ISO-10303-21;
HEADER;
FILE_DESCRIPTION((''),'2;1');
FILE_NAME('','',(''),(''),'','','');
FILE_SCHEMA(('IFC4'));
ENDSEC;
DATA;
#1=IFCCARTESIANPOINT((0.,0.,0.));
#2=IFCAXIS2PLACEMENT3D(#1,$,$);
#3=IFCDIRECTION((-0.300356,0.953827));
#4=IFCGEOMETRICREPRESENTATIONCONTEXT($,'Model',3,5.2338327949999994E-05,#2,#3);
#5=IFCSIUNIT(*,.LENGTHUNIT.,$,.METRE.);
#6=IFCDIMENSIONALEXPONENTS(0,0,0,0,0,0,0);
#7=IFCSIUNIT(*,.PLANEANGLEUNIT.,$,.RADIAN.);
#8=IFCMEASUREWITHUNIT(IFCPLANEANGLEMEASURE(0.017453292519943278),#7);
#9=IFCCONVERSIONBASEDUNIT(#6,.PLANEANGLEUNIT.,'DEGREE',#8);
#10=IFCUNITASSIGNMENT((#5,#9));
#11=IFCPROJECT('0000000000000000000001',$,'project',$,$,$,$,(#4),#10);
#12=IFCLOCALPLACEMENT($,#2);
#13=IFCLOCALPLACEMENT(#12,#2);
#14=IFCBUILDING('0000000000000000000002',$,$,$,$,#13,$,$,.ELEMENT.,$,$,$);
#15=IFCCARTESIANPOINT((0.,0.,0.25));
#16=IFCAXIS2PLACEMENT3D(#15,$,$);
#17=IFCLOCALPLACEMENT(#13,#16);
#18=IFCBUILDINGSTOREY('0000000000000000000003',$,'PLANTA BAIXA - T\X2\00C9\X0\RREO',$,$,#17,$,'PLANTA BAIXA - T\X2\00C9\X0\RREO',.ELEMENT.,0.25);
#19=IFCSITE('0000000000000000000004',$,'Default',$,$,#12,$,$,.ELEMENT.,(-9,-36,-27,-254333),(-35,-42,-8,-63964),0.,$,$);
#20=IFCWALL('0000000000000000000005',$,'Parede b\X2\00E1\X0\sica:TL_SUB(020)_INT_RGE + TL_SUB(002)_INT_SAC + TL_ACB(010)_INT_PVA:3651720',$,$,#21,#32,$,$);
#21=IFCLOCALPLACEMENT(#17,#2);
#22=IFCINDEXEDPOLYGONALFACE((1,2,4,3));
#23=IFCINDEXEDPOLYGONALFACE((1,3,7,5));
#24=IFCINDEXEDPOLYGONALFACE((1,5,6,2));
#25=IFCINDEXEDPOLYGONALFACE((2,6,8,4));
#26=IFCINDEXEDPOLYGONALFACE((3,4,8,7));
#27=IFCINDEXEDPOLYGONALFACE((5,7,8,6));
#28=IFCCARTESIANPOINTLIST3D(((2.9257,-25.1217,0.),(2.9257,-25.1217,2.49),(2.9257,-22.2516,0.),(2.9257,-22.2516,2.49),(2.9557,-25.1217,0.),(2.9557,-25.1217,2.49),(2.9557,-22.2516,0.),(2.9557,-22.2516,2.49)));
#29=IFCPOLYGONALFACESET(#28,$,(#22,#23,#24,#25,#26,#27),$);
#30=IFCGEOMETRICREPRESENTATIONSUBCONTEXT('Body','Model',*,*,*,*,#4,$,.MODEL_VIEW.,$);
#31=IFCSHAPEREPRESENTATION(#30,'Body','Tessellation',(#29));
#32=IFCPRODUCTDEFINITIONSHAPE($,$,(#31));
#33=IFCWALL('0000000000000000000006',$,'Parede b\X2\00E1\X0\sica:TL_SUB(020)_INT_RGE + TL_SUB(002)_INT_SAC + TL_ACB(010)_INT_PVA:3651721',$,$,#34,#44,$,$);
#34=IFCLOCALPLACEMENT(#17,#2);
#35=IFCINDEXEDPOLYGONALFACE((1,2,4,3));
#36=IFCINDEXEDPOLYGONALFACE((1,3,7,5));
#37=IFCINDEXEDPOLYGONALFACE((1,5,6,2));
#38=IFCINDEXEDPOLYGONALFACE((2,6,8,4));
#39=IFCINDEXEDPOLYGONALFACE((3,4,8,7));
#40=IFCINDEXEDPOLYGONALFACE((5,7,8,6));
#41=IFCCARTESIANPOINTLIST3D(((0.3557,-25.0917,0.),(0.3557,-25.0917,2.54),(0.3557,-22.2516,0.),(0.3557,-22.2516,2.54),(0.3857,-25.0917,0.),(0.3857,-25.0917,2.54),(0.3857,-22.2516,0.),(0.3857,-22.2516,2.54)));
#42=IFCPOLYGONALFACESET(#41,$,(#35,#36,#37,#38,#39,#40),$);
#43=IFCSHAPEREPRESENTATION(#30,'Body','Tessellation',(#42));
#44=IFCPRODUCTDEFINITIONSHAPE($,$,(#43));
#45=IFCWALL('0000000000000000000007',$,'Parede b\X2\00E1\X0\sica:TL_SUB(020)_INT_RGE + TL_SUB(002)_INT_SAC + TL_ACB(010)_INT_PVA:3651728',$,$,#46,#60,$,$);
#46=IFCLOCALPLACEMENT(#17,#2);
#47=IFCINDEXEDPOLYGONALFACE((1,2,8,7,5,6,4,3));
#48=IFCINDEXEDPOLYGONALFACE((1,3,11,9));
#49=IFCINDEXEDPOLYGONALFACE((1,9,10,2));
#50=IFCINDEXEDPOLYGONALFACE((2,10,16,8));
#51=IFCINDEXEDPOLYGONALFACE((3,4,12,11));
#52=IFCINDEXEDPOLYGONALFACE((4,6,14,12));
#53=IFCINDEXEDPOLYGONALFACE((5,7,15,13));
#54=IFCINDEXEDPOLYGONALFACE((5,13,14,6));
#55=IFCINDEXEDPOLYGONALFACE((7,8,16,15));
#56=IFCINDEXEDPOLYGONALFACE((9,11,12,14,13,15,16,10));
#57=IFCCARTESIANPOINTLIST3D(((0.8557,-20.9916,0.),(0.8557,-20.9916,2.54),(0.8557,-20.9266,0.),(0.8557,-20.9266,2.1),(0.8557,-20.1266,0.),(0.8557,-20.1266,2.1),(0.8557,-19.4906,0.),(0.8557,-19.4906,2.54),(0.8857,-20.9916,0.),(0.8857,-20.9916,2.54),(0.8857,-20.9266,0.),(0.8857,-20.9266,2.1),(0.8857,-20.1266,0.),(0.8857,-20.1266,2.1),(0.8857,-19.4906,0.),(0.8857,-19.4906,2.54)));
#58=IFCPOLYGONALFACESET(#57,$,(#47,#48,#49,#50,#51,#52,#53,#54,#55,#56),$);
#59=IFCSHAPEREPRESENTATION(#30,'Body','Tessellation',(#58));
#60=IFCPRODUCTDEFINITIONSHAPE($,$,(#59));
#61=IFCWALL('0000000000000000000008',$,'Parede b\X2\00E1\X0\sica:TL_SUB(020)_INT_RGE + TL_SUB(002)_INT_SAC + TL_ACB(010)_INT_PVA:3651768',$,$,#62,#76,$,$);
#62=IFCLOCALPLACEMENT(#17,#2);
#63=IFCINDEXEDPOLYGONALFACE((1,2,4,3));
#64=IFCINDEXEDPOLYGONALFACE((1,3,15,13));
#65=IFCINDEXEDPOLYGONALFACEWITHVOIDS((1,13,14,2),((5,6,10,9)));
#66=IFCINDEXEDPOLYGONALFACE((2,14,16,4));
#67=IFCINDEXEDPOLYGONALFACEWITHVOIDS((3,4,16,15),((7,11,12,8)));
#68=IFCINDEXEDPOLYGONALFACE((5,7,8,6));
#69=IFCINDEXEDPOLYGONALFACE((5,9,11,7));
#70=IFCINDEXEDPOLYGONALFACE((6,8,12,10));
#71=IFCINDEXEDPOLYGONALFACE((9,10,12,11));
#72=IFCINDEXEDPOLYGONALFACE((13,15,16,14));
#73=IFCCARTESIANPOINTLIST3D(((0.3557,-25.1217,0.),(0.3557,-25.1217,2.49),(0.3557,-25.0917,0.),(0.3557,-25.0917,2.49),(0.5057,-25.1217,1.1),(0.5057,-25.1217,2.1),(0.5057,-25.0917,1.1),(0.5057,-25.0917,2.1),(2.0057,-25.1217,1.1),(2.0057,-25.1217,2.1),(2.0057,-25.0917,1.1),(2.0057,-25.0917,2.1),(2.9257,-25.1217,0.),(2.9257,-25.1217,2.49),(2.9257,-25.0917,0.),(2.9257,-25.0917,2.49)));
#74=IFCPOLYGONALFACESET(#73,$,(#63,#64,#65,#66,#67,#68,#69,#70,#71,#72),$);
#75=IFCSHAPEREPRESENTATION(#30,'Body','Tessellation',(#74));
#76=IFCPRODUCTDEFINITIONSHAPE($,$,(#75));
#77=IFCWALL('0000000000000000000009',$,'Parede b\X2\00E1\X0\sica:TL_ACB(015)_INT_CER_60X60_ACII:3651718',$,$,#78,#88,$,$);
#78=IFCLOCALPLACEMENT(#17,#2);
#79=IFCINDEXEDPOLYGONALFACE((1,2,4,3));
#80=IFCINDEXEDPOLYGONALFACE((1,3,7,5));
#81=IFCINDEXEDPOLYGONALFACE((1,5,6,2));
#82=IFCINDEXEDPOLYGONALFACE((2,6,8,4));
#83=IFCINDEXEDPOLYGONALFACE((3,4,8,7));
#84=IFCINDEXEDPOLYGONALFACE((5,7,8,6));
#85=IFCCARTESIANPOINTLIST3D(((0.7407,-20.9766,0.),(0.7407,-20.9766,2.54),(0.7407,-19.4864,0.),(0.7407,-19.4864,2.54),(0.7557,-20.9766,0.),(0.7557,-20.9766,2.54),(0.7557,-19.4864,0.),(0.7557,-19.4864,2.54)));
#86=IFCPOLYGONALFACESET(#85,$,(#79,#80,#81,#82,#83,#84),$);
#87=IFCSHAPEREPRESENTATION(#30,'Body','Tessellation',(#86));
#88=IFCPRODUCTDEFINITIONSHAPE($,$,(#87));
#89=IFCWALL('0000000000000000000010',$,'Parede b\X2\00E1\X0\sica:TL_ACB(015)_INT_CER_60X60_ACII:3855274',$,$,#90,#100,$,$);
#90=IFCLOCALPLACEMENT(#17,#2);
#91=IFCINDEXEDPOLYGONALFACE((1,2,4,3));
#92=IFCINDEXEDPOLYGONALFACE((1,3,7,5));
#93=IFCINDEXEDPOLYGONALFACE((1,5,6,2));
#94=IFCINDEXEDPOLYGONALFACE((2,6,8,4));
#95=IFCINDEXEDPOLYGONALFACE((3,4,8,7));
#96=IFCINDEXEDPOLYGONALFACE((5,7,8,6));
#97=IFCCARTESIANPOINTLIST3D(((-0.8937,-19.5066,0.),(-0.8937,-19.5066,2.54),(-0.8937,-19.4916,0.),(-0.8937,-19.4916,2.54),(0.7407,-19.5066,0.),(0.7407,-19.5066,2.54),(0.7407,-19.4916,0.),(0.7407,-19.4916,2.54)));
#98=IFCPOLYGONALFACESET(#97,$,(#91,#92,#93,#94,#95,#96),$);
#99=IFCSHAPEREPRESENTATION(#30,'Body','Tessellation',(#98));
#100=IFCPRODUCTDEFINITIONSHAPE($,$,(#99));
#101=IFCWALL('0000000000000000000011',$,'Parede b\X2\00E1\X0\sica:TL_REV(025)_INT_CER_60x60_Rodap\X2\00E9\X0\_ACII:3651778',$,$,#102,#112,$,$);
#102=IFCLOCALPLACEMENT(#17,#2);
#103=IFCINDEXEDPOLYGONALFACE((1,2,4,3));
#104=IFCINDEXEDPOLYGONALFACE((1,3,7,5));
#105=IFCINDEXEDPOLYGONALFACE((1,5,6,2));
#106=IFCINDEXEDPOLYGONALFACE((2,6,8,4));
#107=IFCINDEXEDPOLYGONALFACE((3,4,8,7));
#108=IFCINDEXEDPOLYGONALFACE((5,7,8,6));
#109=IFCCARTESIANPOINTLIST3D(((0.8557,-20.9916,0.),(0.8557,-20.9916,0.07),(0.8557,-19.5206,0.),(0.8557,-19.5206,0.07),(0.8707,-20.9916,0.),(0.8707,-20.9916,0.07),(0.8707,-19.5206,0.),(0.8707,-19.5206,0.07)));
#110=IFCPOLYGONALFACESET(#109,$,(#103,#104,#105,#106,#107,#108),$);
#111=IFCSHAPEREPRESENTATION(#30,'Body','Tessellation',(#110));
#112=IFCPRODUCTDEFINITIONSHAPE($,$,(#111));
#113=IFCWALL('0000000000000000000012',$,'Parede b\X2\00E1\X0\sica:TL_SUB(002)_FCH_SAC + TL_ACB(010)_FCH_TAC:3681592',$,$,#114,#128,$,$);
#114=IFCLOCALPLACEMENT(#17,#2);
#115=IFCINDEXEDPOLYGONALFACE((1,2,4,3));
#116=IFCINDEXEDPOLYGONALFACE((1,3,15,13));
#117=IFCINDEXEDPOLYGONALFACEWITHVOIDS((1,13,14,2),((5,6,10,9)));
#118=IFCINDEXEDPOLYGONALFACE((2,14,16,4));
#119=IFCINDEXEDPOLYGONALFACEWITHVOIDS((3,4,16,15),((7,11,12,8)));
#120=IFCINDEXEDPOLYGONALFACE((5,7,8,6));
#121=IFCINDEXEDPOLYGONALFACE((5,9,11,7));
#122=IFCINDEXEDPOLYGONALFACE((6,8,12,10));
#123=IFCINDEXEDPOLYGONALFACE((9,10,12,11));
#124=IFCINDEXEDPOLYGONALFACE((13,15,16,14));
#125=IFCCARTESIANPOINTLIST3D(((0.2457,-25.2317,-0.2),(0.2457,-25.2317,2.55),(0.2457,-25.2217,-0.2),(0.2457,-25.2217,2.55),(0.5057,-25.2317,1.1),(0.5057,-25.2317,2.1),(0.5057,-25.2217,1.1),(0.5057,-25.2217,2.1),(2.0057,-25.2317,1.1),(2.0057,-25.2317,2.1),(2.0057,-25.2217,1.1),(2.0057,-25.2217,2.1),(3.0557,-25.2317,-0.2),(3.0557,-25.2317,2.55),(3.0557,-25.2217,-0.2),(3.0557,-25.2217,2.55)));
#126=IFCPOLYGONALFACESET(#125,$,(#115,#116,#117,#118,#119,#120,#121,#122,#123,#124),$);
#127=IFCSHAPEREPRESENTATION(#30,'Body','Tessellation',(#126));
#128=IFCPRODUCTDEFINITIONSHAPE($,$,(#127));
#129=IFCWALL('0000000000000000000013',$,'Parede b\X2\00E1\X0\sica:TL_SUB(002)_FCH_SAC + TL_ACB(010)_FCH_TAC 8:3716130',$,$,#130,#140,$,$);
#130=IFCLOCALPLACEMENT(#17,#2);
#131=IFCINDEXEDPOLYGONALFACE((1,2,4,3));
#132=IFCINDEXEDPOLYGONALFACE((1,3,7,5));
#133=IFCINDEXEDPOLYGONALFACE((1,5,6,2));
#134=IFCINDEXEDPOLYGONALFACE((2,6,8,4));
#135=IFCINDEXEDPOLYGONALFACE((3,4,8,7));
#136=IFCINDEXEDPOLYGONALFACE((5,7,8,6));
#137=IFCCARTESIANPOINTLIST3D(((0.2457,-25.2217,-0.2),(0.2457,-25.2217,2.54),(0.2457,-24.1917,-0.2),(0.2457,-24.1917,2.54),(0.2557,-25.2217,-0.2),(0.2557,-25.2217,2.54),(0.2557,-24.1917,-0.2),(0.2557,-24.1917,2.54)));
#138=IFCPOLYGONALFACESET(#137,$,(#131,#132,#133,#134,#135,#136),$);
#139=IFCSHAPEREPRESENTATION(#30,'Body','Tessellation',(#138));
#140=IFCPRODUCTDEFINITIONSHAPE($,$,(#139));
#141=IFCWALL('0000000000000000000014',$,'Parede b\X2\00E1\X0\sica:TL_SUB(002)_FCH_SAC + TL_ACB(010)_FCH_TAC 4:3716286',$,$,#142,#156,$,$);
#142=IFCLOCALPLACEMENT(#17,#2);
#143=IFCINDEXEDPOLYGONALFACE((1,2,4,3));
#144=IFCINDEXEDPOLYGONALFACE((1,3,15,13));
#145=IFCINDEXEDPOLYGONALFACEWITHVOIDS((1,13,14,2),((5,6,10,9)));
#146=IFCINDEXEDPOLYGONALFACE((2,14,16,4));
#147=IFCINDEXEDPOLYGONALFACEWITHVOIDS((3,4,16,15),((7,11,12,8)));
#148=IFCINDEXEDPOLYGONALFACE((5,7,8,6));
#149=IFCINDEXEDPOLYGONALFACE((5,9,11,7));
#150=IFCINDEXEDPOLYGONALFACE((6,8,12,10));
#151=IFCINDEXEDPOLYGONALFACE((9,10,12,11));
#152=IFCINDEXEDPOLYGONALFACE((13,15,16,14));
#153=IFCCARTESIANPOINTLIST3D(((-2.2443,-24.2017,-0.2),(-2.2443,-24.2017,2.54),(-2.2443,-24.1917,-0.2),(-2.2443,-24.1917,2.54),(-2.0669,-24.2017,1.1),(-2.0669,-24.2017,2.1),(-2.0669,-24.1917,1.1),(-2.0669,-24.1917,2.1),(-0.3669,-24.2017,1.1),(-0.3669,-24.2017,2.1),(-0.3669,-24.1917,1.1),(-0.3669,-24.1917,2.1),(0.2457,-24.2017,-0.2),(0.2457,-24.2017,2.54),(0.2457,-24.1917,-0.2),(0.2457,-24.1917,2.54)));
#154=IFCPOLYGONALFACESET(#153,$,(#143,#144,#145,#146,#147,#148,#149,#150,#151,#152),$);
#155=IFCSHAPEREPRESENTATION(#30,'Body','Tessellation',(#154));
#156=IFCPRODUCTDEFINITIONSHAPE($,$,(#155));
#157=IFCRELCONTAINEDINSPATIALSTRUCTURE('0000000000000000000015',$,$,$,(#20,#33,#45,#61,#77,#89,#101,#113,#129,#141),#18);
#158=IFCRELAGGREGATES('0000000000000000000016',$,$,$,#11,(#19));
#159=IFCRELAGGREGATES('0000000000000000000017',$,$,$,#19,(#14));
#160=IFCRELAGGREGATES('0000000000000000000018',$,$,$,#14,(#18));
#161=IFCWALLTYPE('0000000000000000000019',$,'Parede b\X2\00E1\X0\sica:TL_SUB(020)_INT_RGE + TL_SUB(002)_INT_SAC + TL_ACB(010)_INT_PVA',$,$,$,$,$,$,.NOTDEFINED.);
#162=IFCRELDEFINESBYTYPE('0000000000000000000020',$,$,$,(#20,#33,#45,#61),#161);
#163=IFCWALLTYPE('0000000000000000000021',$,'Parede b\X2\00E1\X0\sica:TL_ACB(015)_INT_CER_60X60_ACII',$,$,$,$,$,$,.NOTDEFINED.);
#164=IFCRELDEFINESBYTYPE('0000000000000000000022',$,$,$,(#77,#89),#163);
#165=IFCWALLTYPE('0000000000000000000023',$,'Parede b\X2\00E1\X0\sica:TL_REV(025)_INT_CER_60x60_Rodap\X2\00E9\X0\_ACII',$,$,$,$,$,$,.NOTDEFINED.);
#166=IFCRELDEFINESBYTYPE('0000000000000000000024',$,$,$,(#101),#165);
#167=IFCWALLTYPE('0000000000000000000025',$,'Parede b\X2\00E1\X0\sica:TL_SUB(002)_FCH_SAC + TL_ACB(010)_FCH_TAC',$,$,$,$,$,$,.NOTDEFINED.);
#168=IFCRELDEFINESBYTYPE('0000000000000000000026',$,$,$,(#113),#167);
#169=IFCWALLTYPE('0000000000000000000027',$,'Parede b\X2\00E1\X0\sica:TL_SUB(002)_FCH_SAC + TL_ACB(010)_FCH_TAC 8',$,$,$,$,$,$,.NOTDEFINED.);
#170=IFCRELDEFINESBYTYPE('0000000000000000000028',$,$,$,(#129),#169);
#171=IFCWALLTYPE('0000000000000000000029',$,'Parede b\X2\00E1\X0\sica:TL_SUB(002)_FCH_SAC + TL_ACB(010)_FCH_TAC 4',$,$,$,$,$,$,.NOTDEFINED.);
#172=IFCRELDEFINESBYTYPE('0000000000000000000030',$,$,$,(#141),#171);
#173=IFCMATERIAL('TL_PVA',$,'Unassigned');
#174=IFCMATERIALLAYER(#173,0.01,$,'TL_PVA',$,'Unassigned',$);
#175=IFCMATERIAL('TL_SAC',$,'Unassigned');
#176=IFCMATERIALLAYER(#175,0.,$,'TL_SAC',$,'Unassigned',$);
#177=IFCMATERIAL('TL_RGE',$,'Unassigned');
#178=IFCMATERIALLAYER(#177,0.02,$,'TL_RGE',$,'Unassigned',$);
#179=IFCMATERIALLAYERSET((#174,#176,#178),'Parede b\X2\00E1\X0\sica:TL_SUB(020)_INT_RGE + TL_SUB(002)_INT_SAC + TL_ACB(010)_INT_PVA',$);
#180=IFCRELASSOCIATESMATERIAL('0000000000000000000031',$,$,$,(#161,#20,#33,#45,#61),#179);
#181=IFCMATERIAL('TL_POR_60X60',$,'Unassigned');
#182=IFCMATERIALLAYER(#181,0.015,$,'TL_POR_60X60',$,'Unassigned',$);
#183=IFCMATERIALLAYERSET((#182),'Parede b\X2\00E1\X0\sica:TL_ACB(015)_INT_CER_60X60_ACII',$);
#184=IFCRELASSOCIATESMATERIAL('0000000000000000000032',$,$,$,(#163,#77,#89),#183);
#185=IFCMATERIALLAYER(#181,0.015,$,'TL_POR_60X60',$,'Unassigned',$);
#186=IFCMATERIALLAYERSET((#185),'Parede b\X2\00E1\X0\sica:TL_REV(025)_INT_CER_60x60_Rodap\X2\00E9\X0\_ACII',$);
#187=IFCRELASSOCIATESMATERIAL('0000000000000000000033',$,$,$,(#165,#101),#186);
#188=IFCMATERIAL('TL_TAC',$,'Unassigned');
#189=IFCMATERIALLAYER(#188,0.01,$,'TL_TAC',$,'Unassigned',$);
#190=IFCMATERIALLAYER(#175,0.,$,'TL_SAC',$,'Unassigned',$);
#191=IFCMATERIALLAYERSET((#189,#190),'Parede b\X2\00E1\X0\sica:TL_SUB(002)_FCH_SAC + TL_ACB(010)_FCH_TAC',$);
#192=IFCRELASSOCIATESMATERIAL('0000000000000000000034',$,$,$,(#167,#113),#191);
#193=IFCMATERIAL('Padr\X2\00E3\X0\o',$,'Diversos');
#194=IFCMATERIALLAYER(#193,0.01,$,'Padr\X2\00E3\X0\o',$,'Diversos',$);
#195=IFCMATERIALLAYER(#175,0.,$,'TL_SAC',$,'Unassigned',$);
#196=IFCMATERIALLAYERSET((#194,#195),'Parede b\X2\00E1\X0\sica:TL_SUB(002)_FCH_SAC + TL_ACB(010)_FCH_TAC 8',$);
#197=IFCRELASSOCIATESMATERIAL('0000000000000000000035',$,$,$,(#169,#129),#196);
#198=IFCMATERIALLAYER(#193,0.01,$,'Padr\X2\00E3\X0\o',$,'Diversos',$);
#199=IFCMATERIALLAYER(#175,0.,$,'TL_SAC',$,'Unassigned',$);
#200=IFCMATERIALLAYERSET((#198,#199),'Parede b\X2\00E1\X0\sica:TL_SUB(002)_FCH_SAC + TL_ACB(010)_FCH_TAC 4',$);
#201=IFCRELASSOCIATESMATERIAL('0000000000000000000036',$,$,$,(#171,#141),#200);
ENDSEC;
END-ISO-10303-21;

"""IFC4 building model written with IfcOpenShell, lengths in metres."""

from ifc_helpers import new_model, entity, si_unit, converted_unit, direction, frame, frame_2d, origin, place, context, subcontext, project, spatial, rectangle, extrude, material, layer, layer_set, layer_usage, type_object, element, save


model = new_model("IFC4")

# Units and contexts
model_context = context("Model", 3, precision=5.2338327949999994e-05, world=origin(), true_north=direction((-0.300356, 0.953827)))
body_context = subcontext(model_context, "Body", "Model", "MODEL_VIEW")
ifc_project = project(units=[si_unit("LENGTHUNIT", "METRE"), converted_unit("PLANEANGLEUNIT", "DEGREE", entity("IfcPlaneAngleMeasure", 0.017453292519943278), si_unit("PLANEANGLEUNIT", "RADIAN"), dimensions=[0, 0, 0, 0, 0, 0, 0])], contexts=[model_context])

# Site, building, storey
site_placement = place(None, origin())
site = spatial("IfcSite", under=ifc_project, at=site_placement, Name="Default", CompositionType="ELEMENT", RefLatitude=(-9, -36, -27, -254333), RefLongitude=(-35, -42, -8, -63964), RefElevation=0.0)
building_placement = place(site_placement, origin())
building = spatial("IfcBuilding", under=site, at=building_placement, CompositionType="ELEMENT")
storey_placement = place(building_placement, frame((0.0, 0.0, 0.25)))
storey = spatial("IfcBuildingStorey", under=building, at=storey_placement, Name="PLANTA BAIXA - TÉRREO", LongName="PLANTA BAIXA - TÉRREO", CompositionType="ELEMENT", Elevation=0.25)

# Shared definitions
ifc_material_1 = material(Name="TL_PVA", Category="Unassigned")
ifc_layer_1 = layer(ifc_material_1, 0.01, Name="TL_PVA", Category="Unassigned")
ifc_material_2 = material(Name="TL_SAC", Category="Unassigned")
ifc_layer_2 = layer(ifc_material_2, 0.0, Name="TL_SAC", Category="Unassigned")
ifc_material_3 = material(Name="TL_RGE", Category="Unassigned")
ifc_layer_3 = layer(ifc_material_3, 0.02, Name="TL_RGE", Category="Unassigned")
ifc_layer_set_1 = layer_set([ifc_layer_1, ifc_layer_2, ifc_layer_3], Name="Parede básica:TL_SUB(020)_INT_RGE + TL_SUB(002)_INT_SAC + TL_ACB(010)_INT_PVA")
wall_type_1 = type_object("IfcWallType", Name="Parede básica:TL_SUB(020)_INT_RGE + TL_SUB(002)_INT_SAC + TL_ACB(010)_INT_PVA", PredefinedType="NOTDEFINED", material=ifc_layer_set_1)

# Walls
ifc_layer_usage_1 = layer_usage(ifc_layer_set_1, "AXIS2", "POSITIVE", -0.015)
wall_1_placement = place(storey_placement, frame((2.9407, -22.2516, 0.0), z_axis=(0.0, 0.0, 1.0), x_axis=(0.0, -1.0, 0.0)))
element("IfcWall", 1, at=wall_1_placement, inside=storey, type_object=wall_type_1, material=ifc_layer_usage_1, Name="Parede básica:TL_SUB(020)_INT_RGE + TL_SUB(002)_INT_SAC + TL_ACB(010)_INT_PVA:3651720", context=body_context, shape_type="SweptSolid", body=[
    extrude(rectangle(XDim=2.8701, YDim=0.03, at=frame_2d((1.4351, 0.0), x_axis=(-1.0, 0.0))), origin(), (0.0, 0.0, 1.0), 2.49),
])
ifc_layer_usage_2 = layer_usage(ifc_layer_set_1, "AXIS2", "POSITIVE", -0.015)
wall_2_placement = place(storey_placement, frame((0.3707, -25.0917, 0.0), z_axis=(0.0, 0.0, 1.0), x_axis=(0.0, 1.0, 0.0)))
element("IfcWall", 2, at=wall_2_placement, inside=storey, type_object=wall_type_1, material=ifc_layer_usage_2, Name="Parede básica:TL_SUB(020)_INT_RGE + TL_SUB(002)_INT_SAC + TL_ACB(010)_INT_PVA:3651721", context=body_context, shape_type="SweptSolid", body=[
    extrude(rectangle(XDim=2.8401, YDim=0.03, at=frame_2d((1.4201, 0.0), x_axis=(-1.0, 0.0))), origin(), (0.0, 0.0, 1.0), 2.54),
])

# Walls, openings
ifc_layer_usage_3 = layer_usage(ifc_layer_set_1, "AXIS2", "POSITIVE", -0.015)
wall_3_placement = place(storey_placement, frame((0.8707, -20.9916, 0.0), z_axis=(0.0, 0.0, 1.0), x_axis=(0.0, 1.0, 0.0)))
wall_3 = element("IfcWall", 3, at=wall_3_placement, inside=storey, type_object=wall_type_1, material=ifc_layer_usage_3, Name="Parede básica:TL_SUB(020)_INT_RGE + TL_SUB(002)_INT_SAC + TL_ACB(010)_INT_PVA:3651728", context=body_context, shape_type="SweptSolid", body=[
    extrude(rectangle(XDim=1.501, YDim=0.03, at=frame_2d((0.7505, 0.0), x_axis=(-1.0, 0.0))), origin(), (0.0, 0.0, 1.0), 2.54),
])
opening_1_placement = place(wall_3_placement, frame((0.065, -0.015, 0.0)))
element("IfcOpeningElement", 4, at=opening_1_placement, cuts=wall_3, PredefinedType="OPENING", context=body_context, shape_type="SweptSolid", body=[
    extrude(rectangle(XDim=2.1, YDim=0.8, at=frame_2d((1.05, 0.4), x_axis=(1.0, 0.0))), frame((0.0, 0.0, 0.0), z_axis=(0.0, 1.0, 0.0), x_axis=(0.0, 0.0, 1.0)), (0.0, 0.0, 1.0), 0.03),
])
ifc_layer_usage_4 = layer_usage(ifc_layer_set_1, "AXIS2", "POSITIVE", -0.015)
wall_4_placement = place(storey_placement, frame((2.9257, -25.1067, 0.0), z_axis=(0.0, 0.0, 1.0), x_axis=(-1.0, 0.0, 0.0)))
wall_4 = element("IfcWall", 5, at=wall_4_placement, inside=storey, type_object=wall_type_1, material=ifc_layer_usage_4, Name="Parede básica:TL_SUB(020)_INT_RGE + TL_SUB(002)_INT_SAC + TL_ACB(010)_INT_PVA:3651768", context=body_context, shape_type="SweptSolid", body=[
    extrude(rectangle(XDim=2.57, YDim=0.03, at=frame_2d((1.285, 0.0), x_axis=(-1.0, 0.0))), origin(), (0.0, 0.0, 1.0), 2.49),
])
opening_2_placement = place(wall_4_placement, frame((2.9257, -25.1067, 1.1)))
element("IfcOpeningElement", 6, at=opening_2_placement, cuts=wall_4, PredefinedType="OPENING", context=body_context, shape_type="SweptSolid", body=[
    extrude(rectangle(XDim=1.0, YDim=1.5, at=frame_2d((0.0, 0.0), x_axis=(0.0, 1.0))), frame((-1.2557, 23.5977, 0.5), z_axis=(0.0, 1.0, 0.0), x_axis=(1.0, 0.0, 0.0)), (0.0, 0.0, 1.0), 3.048),
])

# Walls
ifc_material_4 = material(Name="TL_POR_60X60", Category="Unassigned")
ifc_layer_4 = layer(ifc_material_4, 0.015, Name="TL_POR_60X60", Category="Unassigned")
ifc_layer_set_2 = layer_set([ifc_layer_4], Name="Parede básica:TL_ACB(015)_INT_CER_60X60_ACII")
ifc_layer_usage_5 = layer_usage(ifc_layer_set_2, "AXIS2", "POSITIVE", -0.0075)
wall_type_2 = type_object("IfcWallType", Name="Parede básica:TL_ACB(015)_INT_CER_60X60_ACII", PredefinedType="NOTDEFINED", material=ifc_layer_set_2)
wall_5_placement = place(storey_placement, frame((0.7482, -19.4864, 0.0), z_axis=(0.0, 0.0, 1.0), x_axis=(0.0, -1.0, 0.0)))
element("IfcWall", 7, at=wall_5_placement, inside=storey, type_object=wall_type_2, material=ifc_layer_usage_5, Name="Parede básica:TL_ACB(015)_INT_CER_60X60_ACII:3651718", context=body_context, shape_type="SweptSolid", body=[
    extrude(rectangle(XDim=1.4902, YDim=0.015, at=frame_2d((0.7451, 0.0), x_axis=(-1.0, 0.0))), origin(), (0.0, 0.0, 1.0), 2.54),
])
ifc_layer_usage_6 = layer_usage(ifc_layer_set_2, "AXIS2", "NEGATIVE", 0.0075)
wall_6_placement = place(storey_placement, frame((0.7407, -19.4991, 0.0), z_axis=(0.0, 0.0, 1.0), x_axis=(-1.0, 0.0, 0.0)))
element("IfcWall", 8, at=wall_6_placement, inside=storey, type_object=wall_type_2, material=ifc_layer_usage_6, Name="Parede básica:TL_ACB(015)_INT_CER_60X60_ACII:3855274", context=body_context, shape_type="SweptSolid", body=[
    extrude(rectangle(XDim=1.6345, YDim=0.015, at=frame_2d((0.8172, 0.0), x_axis=(-1.0, 0.0))), origin(), (0.0, 0.0, 1.0), 2.54),
])
ifc_layer_5 = layer(ifc_material_4, 0.015, Name="TL_POR_60X60", Category="Unassigned")
ifc_layer_set_3 = layer_set([ifc_layer_5], Name="Parede básica:TL_REV(025)_INT_CER_60x60_Rodapé_ACII")
ifc_layer_usage_7 = layer_usage(ifc_layer_set_3, "AXIS2", "NEGATIVE", 0.0075)
wall_type_3 = type_object("IfcWallType", Name="Parede básica:TL_REV(025)_INT_CER_60x60_Rodapé_ACII", PredefinedType="NOTDEFINED", material=ifc_layer_set_3)
wall_7_placement = place(storey_placement, frame((0.8632, -19.5206, 0.0), z_axis=(0.0, 0.0, 1.0), x_axis=(0.0, -1.0, 0.0)))
element("IfcWall", 9, at=wall_7_placement, inside=storey, type_object=wall_type_3, material=ifc_layer_usage_7, Name="Parede básica:TL_REV(025)_INT_CER_60x60_Rodapé_ACII:3651778", context=body_context, shape_type="SweptSolid", body=[
    extrude(rectangle(XDim=1.471, YDim=0.015, at=frame_2d((0.7355, 0.0), x_axis=(-1.0, 0.0))), origin(), (0.0, 0.0, 1.0), 0.07),
])

# Wall, opening
ifc_material_5 = material(Name="TL_TAC", Category="Unassigned")
ifc_layer_6 = layer(ifc_material_5, 0.01, Name="TL_TAC", Category="Unassigned")
ifc_layer_7 = layer(ifc_material_2, 0.0, Name="TL_SAC", Category="Unassigned")
ifc_layer_set_4 = layer_set([ifc_layer_6, ifc_layer_7], Name="Parede básica:TL_SUB(002)_FCH_SAC + TL_ACB(010)_FCH_TAC")
ifc_layer_usage_8 = layer_usage(ifc_layer_set_4, "AXIS2", "NEGATIVE", 0.005)
wall_type_4 = type_object("IfcWallType", Name="Parede básica:TL_SUB(002)_FCH_SAC + TL_ACB(010)_FCH_TAC", PredefinedType="NOTDEFINED", material=ifc_layer_set_4)
wall_8_placement = place(storey_placement, frame((3.0557, -25.2267, -0.2), z_axis=(0.0, 0.0, 1.0), x_axis=(-1.0, 0.0, 0.0)))
wall_8 = element("IfcWall", 10, at=wall_8_placement, inside=storey, type_object=wall_type_4, material=ifc_layer_usage_8, Name="Parede básica:TL_SUB(002)_FCH_SAC + TL_ACB(010)_FCH_TAC:3681592", context=body_context, shape_type="SweptSolid", body=[
    extrude(rectangle(XDim=2.81, YDim=0.01, at=frame_2d((1.405, 0.0), x_axis=(-1.0, 0.0))), origin(), (0.0, 0.0, 1.0), 2.75),
])
opening_3_placement = place(wall_8_placement, frame((3.0557, -25.2267, 1.3)))
element("IfcOpeningElement", 11, at=opening_3_placement, cuts=wall_8, PredefinedType="OPENING", context=body_context, shape_type="SweptSolid", body=[
    extrude(rectangle(XDim=1.0, YDim=1.5, at=frame_2d((0.0, 0.0), x_axis=(0.0, 1.0))), frame((-1.2557, 23.5977, 0.5), z_axis=(0.0, 1.0, 0.0), x_axis=(1.0, 0.0, 0.0)), (0.0, 0.0, 1.0), 3.048),
])

# Wall
ifc_material_6 = material(Name="Padrão", Category="Diversos")
ifc_layer_8 = layer(ifc_material_6, 0.01, Name="Padrão", Category="Diversos")
ifc_layer_9 = layer(ifc_material_2, 0.0, Name="TL_SAC", Category="Unassigned")
ifc_layer_set_5 = layer_set([ifc_layer_8, ifc_layer_9], Name="Parede básica:TL_SUB(002)_FCH_SAC + TL_ACB(010)_FCH_TAC 8")
ifc_layer_usage_9 = layer_usage(ifc_layer_set_5, "AXIS2", "POSITIVE", -0.005)
wall_type_5 = type_object("IfcWallType", Name="Parede básica:TL_SUB(002)_FCH_SAC + TL_ACB(010)_FCH_TAC 8", PredefinedType="NOTDEFINED", material=ifc_layer_set_5)
wall_9_placement = place(storey_placement, frame((0.2507, -25.2217, -0.2), z_axis=(0.0, 0.0, 1.0), x_axis=(0.0, 1.0, 0.0)))
element("IfcWall", 12, at=wall_9_placement, inside=storey, type_object=wall_type_5, material=ifc_layer_usage_9, Name="Parede básica:TL_SUB(002)_FCH_SAC + TL_ACB(010)_FCH_TAC 8:3716130", context=body_context, shape_type="SweptSolid", body=[
    extrude(rectangle(XDim=1.03, YDim=0.01, at=frame_2d((0.515, 0.0), x_axis=(-1.0, 0.0))), origin(), (0.0, 0.0, 1.0), 2.74),
])

# Wall, opening
ifc_layer_10 = layer(ifc_material_6, 0.01, Name="Padrão", Category="Diversos")
ifc_layer_11 = layer(ifc_material_2, 0.0, Name="TL_SAC", Category="Unassigned")
ifc_layer_set_6 = layer_set([ifc_layer_10, ifc_layer_11], Name="Parede básica:TL_SUB(002)_FCH_SAC + TL_ACB(010)_FCH_TAC 4")
ifc_layer_usage_10 = layer_usage(ifc_layer_set_6, "AXIS2", "POSITIVE", -0.005)
wall_type_6 = type_object("IfcWallType", Name="Parede básica:TL_SUB(002)_FCH_SAC + TL_ACB(010)_FCH_TAC 4", PredefinedType="NOTDEFINED", material=ifc_layer_set_6)
wall_10_placement = place(storey_placement, frame((0.2457, -24.1967, -0.2), z_axis=(0.0, 0.0, 1.0), x_axis=(-1.0, 0.0, 0.0)))
wall_10 = element("IfcWall", 13, at=wall_10_placement, inside=storey, type_object=wall_type_6, material=ifc_layer_usage_10, Name="Parede básica:TL_SUB(002)_FCH_SAC + TL_ACB(010)_FCH_TAC 4:3716286", context=body_context, shape_type="SweptSolid", body=[
    extrude(rectangle(XDim=2.49, YDim=0.01, at=frame_2d((1.245, 0.0), x_axis=(-1.0, 0.0))), origin(), (0.0, 0.0, 1.0), 2.74),
])
opening_4_placement = place(wall_10_placement, frame((0.2457, -24.1967, 1.3)))
element("IfcOpeningElement", 14, at=opening_4_placement, cuts=wall_10, PredefinedType="OPENING", context=body_context, shape_type="SweptSolid", body=[
    extrude(rectangle(XDim=1.0, YDim=1.7, at=frame_2d((0.0, 0.0), x_axis=(0.0, 1.0))), frame((1.2169, 22.5677, 0.5), z_axis=(0.0, 1.0, 0.0), x_axis=(1.0, 0.0, 0.0)), (0.0, 0.0, 1.0), 3.048),
])

save(model, "model.ifc")
